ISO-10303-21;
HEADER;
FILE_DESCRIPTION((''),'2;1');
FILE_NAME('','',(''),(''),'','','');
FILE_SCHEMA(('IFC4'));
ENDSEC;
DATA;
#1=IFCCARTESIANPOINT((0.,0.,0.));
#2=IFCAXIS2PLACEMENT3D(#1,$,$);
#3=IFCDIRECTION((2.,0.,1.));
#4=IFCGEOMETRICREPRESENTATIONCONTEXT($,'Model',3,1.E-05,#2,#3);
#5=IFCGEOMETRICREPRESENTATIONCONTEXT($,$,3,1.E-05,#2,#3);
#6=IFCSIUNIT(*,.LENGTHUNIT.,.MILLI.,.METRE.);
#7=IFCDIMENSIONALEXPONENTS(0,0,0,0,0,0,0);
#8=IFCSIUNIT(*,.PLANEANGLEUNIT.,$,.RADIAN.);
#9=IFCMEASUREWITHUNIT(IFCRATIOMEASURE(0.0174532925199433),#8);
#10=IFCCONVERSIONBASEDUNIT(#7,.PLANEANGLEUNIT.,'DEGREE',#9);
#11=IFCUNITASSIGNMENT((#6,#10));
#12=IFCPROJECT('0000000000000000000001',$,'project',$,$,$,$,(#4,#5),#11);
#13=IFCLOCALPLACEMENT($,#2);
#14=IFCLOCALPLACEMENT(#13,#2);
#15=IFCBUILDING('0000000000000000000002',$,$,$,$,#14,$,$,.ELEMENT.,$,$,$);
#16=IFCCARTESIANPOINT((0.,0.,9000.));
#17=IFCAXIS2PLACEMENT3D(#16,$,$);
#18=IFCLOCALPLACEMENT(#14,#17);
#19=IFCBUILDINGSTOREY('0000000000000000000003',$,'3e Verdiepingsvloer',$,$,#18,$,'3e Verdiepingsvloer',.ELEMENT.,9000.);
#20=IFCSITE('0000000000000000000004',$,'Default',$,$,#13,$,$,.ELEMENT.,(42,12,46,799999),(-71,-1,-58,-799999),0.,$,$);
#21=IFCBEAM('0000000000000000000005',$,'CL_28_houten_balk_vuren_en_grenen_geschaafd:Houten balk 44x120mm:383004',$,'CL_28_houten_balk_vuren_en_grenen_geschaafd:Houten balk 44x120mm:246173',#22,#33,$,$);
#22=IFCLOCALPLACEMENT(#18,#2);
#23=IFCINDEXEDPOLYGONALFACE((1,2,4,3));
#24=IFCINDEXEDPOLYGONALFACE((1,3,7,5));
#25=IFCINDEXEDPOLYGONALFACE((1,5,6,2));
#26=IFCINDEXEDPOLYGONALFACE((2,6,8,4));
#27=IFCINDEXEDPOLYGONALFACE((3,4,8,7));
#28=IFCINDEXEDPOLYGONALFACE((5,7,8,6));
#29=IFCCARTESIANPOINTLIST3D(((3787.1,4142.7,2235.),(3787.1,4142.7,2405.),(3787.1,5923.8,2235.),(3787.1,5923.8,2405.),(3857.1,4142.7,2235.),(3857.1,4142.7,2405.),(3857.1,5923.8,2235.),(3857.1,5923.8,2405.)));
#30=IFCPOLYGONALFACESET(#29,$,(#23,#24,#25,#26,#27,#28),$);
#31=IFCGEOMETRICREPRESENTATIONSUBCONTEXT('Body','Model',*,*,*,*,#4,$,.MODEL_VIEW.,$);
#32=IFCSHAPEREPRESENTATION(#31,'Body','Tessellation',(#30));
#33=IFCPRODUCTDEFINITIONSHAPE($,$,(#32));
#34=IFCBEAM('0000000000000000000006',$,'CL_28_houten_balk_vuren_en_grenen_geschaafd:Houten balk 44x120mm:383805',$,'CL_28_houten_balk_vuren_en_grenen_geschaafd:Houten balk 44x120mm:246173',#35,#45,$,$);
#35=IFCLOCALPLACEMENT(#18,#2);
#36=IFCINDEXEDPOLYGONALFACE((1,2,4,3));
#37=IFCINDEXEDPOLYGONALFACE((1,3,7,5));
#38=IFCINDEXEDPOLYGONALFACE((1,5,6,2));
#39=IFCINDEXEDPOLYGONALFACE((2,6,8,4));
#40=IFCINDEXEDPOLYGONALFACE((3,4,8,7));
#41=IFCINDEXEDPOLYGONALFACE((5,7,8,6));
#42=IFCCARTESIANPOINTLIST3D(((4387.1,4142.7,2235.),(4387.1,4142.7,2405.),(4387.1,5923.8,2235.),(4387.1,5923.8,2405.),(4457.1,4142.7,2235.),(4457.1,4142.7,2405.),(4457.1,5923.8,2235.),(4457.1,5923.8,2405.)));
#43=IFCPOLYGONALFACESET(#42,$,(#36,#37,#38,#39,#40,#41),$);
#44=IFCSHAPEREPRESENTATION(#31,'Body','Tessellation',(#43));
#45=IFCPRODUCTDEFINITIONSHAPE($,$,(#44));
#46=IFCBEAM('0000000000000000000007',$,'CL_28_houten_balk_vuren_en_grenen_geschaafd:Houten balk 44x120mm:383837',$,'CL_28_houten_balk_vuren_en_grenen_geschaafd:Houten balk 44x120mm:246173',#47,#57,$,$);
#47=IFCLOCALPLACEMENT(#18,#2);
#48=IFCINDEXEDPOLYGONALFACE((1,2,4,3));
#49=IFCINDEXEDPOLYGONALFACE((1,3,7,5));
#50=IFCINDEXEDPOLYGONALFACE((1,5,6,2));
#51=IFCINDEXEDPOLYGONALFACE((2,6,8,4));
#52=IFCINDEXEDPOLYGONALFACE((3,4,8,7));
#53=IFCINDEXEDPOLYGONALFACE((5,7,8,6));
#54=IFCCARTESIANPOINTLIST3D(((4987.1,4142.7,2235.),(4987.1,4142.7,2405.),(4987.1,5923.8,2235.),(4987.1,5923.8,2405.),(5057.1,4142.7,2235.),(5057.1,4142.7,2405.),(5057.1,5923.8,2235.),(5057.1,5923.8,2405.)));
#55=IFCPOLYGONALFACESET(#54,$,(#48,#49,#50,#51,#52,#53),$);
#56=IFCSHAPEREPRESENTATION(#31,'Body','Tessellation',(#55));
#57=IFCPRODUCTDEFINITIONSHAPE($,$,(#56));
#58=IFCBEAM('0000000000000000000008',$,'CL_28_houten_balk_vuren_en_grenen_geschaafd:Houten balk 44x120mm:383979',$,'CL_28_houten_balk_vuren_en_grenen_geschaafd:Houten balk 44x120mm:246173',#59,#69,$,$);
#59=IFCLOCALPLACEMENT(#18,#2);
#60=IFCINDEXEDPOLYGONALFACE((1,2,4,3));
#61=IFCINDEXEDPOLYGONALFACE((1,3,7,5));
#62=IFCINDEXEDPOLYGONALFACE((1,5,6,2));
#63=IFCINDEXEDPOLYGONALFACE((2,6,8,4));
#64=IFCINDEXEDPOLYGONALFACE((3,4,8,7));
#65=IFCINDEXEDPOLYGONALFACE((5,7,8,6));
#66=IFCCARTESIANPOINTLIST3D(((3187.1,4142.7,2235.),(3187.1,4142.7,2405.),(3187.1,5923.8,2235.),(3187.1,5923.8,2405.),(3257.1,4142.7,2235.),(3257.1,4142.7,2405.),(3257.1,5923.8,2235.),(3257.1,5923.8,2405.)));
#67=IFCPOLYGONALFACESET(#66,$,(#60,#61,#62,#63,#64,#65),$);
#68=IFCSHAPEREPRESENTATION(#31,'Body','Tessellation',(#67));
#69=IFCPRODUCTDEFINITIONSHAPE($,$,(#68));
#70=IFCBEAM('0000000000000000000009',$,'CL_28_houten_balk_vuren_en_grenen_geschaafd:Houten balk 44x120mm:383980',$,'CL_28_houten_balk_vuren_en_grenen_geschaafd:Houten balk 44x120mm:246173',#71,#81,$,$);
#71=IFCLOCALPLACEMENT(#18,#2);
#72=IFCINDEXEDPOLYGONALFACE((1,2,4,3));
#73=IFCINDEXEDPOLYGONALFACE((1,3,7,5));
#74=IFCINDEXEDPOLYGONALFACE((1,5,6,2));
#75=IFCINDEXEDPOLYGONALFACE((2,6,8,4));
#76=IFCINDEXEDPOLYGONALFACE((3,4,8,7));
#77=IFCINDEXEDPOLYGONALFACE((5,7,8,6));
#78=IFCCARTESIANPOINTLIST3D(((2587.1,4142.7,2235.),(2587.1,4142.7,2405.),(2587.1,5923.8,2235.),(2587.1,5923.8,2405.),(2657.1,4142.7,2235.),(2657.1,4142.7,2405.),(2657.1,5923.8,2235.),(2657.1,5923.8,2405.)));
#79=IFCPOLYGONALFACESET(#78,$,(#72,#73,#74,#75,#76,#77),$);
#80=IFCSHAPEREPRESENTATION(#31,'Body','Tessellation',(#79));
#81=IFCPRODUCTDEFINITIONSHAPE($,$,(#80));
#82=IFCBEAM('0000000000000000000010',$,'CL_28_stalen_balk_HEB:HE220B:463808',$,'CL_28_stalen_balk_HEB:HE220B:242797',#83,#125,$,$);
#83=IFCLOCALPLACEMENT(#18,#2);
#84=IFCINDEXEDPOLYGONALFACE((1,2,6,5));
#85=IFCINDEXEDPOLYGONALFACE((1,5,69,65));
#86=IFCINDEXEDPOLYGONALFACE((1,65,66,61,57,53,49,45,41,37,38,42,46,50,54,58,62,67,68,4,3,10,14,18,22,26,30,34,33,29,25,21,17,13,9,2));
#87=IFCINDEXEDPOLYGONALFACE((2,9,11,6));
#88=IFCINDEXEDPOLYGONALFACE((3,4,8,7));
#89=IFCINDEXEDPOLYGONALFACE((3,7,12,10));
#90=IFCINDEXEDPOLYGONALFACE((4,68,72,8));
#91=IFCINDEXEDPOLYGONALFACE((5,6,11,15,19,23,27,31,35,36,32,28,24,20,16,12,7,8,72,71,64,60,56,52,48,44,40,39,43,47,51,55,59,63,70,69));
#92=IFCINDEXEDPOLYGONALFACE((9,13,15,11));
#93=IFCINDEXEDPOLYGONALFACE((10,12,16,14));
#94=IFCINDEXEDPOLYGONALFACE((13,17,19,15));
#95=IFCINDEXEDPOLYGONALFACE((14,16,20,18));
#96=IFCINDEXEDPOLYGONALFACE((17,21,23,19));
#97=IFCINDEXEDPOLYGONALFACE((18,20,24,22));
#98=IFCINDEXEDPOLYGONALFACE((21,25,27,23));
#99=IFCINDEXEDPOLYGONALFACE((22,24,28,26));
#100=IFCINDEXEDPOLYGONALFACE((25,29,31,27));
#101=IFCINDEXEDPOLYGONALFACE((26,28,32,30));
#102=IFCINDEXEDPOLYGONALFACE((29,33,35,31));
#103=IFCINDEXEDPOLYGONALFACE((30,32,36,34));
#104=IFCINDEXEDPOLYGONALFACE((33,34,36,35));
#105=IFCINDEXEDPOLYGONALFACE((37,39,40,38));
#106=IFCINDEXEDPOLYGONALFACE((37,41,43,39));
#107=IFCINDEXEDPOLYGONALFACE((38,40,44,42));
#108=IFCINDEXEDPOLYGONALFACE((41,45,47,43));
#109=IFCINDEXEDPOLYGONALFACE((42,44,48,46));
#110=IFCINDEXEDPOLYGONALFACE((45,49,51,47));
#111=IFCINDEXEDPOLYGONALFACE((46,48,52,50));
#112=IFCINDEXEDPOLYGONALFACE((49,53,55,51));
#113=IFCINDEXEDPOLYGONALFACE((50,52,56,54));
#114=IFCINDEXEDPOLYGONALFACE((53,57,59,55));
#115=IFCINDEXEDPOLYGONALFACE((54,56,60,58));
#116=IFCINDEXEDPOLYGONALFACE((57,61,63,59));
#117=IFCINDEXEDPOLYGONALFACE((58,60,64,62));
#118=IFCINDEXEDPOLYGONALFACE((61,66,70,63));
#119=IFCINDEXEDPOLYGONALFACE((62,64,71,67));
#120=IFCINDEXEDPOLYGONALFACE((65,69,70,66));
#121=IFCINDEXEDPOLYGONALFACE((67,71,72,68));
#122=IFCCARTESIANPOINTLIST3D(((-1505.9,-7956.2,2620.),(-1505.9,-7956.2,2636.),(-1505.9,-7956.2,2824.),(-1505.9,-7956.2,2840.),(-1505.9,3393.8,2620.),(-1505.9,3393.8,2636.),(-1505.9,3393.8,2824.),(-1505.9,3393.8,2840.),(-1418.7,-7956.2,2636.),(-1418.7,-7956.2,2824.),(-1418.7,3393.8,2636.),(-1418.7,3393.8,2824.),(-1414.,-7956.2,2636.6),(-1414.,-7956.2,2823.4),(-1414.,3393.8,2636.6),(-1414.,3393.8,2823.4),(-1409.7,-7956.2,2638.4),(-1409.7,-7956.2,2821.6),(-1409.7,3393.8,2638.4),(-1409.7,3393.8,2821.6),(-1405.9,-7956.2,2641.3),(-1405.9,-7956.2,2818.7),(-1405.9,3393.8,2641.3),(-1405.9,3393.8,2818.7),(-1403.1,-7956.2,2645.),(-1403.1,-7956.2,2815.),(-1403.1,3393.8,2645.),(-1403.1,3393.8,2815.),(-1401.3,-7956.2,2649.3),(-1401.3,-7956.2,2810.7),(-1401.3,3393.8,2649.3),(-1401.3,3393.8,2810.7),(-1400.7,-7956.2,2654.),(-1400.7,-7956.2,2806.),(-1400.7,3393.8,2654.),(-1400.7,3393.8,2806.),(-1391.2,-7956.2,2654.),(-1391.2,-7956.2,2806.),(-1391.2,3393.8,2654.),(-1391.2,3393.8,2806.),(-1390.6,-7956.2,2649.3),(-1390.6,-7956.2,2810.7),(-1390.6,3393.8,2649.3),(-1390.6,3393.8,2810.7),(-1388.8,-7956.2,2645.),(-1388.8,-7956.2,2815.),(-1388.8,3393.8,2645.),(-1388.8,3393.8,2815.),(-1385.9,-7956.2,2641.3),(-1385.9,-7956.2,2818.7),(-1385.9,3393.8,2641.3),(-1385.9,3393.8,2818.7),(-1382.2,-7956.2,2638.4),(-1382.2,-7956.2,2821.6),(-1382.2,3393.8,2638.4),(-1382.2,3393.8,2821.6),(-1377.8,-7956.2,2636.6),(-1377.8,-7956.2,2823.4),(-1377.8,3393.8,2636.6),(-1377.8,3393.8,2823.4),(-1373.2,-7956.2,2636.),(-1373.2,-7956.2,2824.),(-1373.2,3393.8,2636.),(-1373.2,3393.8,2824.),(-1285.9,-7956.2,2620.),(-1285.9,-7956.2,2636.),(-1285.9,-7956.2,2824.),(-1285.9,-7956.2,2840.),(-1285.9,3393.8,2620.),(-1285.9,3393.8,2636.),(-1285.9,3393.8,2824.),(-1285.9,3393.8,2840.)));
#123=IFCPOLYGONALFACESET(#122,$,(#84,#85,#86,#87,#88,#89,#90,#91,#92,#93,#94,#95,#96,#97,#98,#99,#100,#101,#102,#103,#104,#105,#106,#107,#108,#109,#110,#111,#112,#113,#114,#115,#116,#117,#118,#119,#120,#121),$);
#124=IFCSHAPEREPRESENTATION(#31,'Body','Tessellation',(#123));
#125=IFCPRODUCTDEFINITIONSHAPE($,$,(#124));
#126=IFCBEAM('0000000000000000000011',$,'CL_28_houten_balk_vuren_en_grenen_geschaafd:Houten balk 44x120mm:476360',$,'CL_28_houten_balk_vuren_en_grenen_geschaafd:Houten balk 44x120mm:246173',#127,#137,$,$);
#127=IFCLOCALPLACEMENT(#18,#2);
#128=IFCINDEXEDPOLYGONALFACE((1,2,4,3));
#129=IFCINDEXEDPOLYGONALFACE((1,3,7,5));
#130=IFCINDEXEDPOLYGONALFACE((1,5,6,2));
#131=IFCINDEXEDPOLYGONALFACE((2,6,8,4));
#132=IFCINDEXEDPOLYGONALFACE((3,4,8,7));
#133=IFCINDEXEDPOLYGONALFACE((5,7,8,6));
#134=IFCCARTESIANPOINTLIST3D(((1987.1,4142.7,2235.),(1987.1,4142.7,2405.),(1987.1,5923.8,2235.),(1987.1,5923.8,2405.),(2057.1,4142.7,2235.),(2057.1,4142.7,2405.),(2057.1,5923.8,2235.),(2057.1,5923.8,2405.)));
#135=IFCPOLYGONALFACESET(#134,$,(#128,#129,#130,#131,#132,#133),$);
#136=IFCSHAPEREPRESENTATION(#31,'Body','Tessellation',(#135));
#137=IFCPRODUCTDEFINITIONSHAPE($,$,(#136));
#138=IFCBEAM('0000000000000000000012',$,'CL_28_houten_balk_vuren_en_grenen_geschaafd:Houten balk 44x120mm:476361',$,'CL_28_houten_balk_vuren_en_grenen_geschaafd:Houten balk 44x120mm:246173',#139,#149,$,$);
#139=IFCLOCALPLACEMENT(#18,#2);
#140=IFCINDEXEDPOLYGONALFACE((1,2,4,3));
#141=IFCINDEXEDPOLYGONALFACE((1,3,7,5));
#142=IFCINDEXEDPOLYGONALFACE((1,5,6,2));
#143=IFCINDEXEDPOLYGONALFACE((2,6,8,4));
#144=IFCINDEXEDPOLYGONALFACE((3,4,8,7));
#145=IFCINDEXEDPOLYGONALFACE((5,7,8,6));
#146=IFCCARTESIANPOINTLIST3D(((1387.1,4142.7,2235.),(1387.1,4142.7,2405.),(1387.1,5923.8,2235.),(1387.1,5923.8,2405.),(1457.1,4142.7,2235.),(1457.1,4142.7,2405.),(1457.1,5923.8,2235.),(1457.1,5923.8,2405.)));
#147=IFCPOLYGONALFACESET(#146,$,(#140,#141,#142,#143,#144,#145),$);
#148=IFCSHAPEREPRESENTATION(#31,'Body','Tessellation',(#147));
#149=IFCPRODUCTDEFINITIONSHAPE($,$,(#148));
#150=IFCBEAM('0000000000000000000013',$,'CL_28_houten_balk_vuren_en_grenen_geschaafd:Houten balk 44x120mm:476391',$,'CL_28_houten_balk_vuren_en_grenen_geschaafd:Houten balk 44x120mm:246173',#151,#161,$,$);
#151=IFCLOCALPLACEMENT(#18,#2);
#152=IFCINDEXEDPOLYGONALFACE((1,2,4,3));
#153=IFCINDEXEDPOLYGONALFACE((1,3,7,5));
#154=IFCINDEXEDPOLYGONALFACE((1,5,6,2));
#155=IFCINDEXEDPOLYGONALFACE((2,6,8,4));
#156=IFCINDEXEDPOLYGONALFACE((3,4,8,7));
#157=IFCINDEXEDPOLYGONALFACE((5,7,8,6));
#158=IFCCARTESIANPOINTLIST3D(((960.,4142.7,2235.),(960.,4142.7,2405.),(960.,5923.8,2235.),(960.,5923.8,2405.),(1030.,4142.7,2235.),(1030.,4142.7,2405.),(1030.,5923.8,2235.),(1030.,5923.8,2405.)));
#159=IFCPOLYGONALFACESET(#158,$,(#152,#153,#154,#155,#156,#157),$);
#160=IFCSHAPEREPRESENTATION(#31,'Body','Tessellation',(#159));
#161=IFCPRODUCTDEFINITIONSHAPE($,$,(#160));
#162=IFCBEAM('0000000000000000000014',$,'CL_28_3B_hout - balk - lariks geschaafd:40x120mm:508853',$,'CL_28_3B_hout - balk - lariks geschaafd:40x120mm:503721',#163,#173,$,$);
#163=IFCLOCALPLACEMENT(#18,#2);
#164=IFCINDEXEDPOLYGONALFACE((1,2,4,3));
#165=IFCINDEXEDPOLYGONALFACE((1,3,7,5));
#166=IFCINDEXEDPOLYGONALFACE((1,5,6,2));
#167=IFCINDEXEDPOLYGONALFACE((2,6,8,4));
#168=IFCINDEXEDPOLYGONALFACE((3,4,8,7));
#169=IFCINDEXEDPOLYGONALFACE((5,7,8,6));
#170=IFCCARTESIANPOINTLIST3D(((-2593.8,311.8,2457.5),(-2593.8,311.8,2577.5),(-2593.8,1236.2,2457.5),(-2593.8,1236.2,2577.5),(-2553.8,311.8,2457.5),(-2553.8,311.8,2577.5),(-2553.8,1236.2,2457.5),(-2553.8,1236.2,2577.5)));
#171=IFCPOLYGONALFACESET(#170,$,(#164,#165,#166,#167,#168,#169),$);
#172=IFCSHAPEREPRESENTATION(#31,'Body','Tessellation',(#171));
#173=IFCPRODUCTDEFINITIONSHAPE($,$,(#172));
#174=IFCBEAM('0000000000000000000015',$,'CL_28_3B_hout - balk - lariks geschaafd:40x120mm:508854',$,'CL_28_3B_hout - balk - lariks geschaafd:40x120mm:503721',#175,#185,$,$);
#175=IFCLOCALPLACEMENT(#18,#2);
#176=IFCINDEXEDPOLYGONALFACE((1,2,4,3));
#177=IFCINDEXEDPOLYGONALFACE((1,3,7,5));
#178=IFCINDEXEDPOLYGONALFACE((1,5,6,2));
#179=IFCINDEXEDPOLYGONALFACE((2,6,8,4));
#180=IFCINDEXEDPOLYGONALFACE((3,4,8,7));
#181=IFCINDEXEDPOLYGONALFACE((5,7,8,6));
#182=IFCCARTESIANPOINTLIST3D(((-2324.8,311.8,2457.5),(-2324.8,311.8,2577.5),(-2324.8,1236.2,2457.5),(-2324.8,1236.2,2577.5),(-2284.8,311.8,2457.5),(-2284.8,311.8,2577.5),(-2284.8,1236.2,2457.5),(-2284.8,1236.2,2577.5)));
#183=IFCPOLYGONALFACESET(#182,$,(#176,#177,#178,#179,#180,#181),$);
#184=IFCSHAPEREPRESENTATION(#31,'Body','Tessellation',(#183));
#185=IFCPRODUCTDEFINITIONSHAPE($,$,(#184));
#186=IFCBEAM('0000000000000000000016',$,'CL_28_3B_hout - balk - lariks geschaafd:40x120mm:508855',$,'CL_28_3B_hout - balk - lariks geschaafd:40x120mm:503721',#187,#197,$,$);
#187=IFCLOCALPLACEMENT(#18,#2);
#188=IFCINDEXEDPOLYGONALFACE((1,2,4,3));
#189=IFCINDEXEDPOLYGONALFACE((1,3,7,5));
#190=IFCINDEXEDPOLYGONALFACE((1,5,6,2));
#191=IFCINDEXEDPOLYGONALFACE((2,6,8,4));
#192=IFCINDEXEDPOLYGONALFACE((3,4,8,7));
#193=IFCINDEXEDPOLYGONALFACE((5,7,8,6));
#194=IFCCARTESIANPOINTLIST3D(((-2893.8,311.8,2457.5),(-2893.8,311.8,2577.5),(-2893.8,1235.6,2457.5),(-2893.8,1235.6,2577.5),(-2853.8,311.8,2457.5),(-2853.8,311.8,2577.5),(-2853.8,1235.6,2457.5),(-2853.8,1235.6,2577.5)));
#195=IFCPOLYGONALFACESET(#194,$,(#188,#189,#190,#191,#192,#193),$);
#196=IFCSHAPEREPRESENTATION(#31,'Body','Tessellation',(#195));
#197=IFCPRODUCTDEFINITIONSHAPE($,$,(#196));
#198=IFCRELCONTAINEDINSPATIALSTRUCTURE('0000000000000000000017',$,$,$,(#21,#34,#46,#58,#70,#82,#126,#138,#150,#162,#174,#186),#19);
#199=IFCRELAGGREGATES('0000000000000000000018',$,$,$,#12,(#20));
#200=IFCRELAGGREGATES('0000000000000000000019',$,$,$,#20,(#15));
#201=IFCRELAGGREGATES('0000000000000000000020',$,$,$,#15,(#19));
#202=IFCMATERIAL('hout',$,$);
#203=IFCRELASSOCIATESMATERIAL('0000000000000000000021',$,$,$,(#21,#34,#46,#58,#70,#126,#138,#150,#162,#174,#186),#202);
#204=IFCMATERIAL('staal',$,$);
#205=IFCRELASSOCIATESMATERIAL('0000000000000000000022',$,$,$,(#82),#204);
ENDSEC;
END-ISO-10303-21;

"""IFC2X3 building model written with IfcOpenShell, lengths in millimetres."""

from ifc_helpers import new_model, entity, si_unit, converted_unit, direction, frame, frame_2d, origin, place, context, subcontext, project, spatial, rectangle, i_section, extrude, material, element, save


model = new_model("IFC2X3")

# Units and contexts
model_context = context("Model", 3, precision=1e-05, world=origin(), true_north=direction((2.0, 0.0, 1.0)))
context_of_model = context(None, 3, precision=1e-05, world=origin(), true_north=direction((2.0, 0.0, 1.0)))
body_context = subcontext(model_context, "Body", "Model", "MODEL_VIEW")
ifc_project = project(units=[si_unit("LENGTHUNIT", "METRE", prefix="MILLI"), converted_unit("PLANEANGLEUNIT", "DEGREE", entity("IfcRatioMeasure", 0.0174532925199433), si_unit("PLANEANGLEUNIT", "RADIAN"), dimensions=[0, 0, 0, 0, 0, 0, 0])], contexts=[model_context, context_of_model])

# Site, building, storey
site_placement = place(None, origin())
site = spatial("IfcSite", under=ifc_project, at=site_placement, Name="Default", CompositionType="ELEMENT", RefLatitude=(42, 12, 46, 799999), RefLongitude=(-71, -1, -58, -799999), RefElevation=0.0)
building_placement = place(site_placement, origin())
building = spatial("IfcBuilding", under=site, at=building_placement, CompositionType="ELEMENT")
storey_placement = place(building_placement, frame((0.0, 0.0, 9000.0)))
storey = spatial("IfcBuildingStorey", under=building, at=storey_placement, Name="3e Verdiepingsvloer", LongName="3e Verdiepingsvloer", CompositionType="ELEMENT", Elevation=9000.0)

# Beams
ifc_material_1 = material(Name="staal")
ifc_material_2 = material(Name="hout")
for number, where, z_axis, x_axis, name in (
    (1, (3822.1, 4142.7, 2405.0), (0.0, 0.0, 1.0), (0.0, 1.0, 0.0), "CL_28_houten_balk_vuren_en_grenen_geschaafd:Houten balk 44x120mm:383004"),
    (2, (4422.1, 4142.7, 2405.0), (0.0, 0.0, 1.0), (0.0, 1.0, 0.0), "CL_28_houten_balk_vuren_en_grenen_geschaafd:Houten balk 44x120mm:383805"),
):
    element("IfcBeam", number, at=place(storey_placement, frame(where, z_axis=z_axis, x_axis=x_axis)), inside=storey, material=ifc_material_2, Name=name, ObjectType="CL_28_houten_balk_vuren_en_grenen_geschaafd:Houten balk 44x120mm:246173", context=body_context, shape_type="SweptSolid", body=[
        extrude(rectangle(XDim=170.0, YDim=70.0, at=frame_2d((0.0, 0.0), x_axis=(1.0, 0.0))), frame((0.0, 0.0, -85.0), z_axis=(1.0, 0.0, 0.0), x_axis=(0.0, 0.0, -1.0)), (0.0, 0.0, 1.0), 1781.1),
    ])
beam_1_placement = place(storey_placement, frame((5022.1, 4142.7, 2405.0), z_axis=(0.0, 0.0, 1.0), x_axis=(0.0, 1.0, 0.0)))
element("IfcBeam", 3, at=beam_1_placement, inside=storey, material=ifc_material_2, Name="CL_28_houten_balk_vuren_en_grenen_geschaafd:Houten balk 44x120mm:383837", ObjectType="CL_28_houten_balk_vuren_en_grenen_geschaafd:Houten balk 44x120mm:246173", context=body_context, shape_type="SweptSolid", body=[
    extrude(rectangle(XDim=170.0, YDim=70.0, at=frame_2d((0.0, 0.0), x_axis=(1.0, 0.0))), frame((0.0, 0.0, -85.0), z_axis=(1.0, 0.0, 0.0), x_axis=(0.0, 0.0, -1.0)), (0.0, 0.0, 1.0), 1781.1),
])
for number, where, z_axis, x_axis, name in (
    (4, (3222.1, 4142.7, 2405.0), (0.0, 0.0, 1.0), (0.0, 1.0, 0.0), "CL_28_houten_balk_vuren_en_grenen_geschaafd:Houten balk 44x120mm:383979"),
    (5, (2622.1, 4142.7, 2405.0), (0.0, 0.0, 1.0), (0.0, 1.0, 0.0), "CL_28_houten_balk_vuren_en_grenen_geschaafd:Houten balk 44x120mm:383980"),
):
    element("IfcBeam", number, at=place(storey_placement, frame(where, z_axis=z_axis, x_axis=x_axis)), inside=storey, material=ifc_material_2, Name=name, ObjectType="CL_28_houten_balk_vuren_en_grenen_geschaafd:Houten balk 44x120mm:246173", context=body_context, shape_type="SweptSolid", body=[
        extrude(rectangle(XDim=170.0, YDim=70.0, at=frame_2d((0.0, 0.0), x_axis=(1.0, 0.0))), frame((0.0, 0.0, -85.0), z_axis=(1.0, 0.0, 0.0), x_axis=(0.0, 0.0, -1.0)), (0.0, 0.0, 1.0), 1781.1),
    ])
beam_2_placement = place(storey_placement, frame((-1395.9, -7956.2, 2840.0), z_axis=(0.0, 0.0, 1.0), x_axis=(0.0, 1.0, 0.0)))
element("IfcBeam", 6, at=beam_2_placement, inside=storey, material=ifc_material_1, Name="CL_28_stalen_balk_HEB:HE220B:463808", ObjectType="CL_28_stalen_balk_HEB:HE220B:242797", context=body_context, shape_type="SweptSolid", body=[
    extrude(i_section(OverallWidth=220.0, OverallDepth=220.0, WebThickness=9.5, FlangeThickness=16.0, FilletRadius=18.0, at=frame_2d((0.0, 0.0), x_axis=(0.0, 1.0))), frame((0.0, 0.0, -110.0), z_axis=(1.0, 0.0, 0.0), x_axis=(0.0, 0.0, -1.0)), (0.0, 0.0, 1.0), 11350.0),
])
for number, where, z_axis, x_axis, name in (
    (7, (2022.1, 4142.7, 2405.0), (0.0, 0.0, 1.0), (0.0, 1.0, 0.0), "CL_28_houten_balk_vuren_en_grenen_geschaafd:Houten balk 44x120mm:476360"),
    (8, (1422.1, 4142.7, 2405.0), (0.0, 0.0, 1.0), (0.0, 1.0, 0.0), "CL_28_houten_balk_vuren_en_grenen_geschaafd:Houten balk 44x120mm:476361"),
):
    element("IfcBeam", number, at=place(storey_placement, frame(where, z_axis=z_axis, x_axis=x_axis)), inside=storey, material=ifc_material_2, Name=name, ObjectType="CL_28_houten_balk_vuren_en_grenen_geschaafd:Houten balk 44x120mm:246173", context=body_context, shape_type="SweptSolid", body=[
        extrude(rectangle(XDim=170.0, YDim=70.0, at=frame_2d((0.0, 0.0), x_axis=(1.0, 0.0))), frame((0.0, 0.0, -85.0), z_axis=(1.0, 0.0, 0.0), x_axis=(0.0, 0.0, -1.0)), (0.0, 0.0, 1.0), 1781.1),
    ])
beam_3_placement = place(storey_placement, frame((995.0, 4142.7, 2405.0), z_axis=(0.0, 0.0, 1.0), x_axis=(0.0, 1.0, 0.0)))
element("IfcBeam", 9, at=beam_3_placement, inside=storey, material=ifc_material_2, Name="CL_28_houten_balk_vuren_en_grenen_geschaafd:Houten balk 44x120mm:476391", ObjectType="CL_28_houten_balk_vuren_en_grenen_geschaafd:Houten balk 44x120mm:246173", context=body_context, shape_type="SweptSolid", body=[
    extrude(rectangle(XDim=170.0, YDim=70.0, at=frame_2d((0.0, 0.0), x_axis=(1.0, 0.0))), frame((0.0, 0.0, -85.0), z_axis=(1.0, 0.0, 0.0), x_axis=(0.0, 0.0, -1.0)), (0.0, 0.0, 1.0), 1781.1),
])
beam_4_placement = place(storey_placement, frame((-2573.8, 1304.8, 2577.5), z_axis=(0.0, 0.0, 1.0), x_axis=(0.0, -1.0, 0.0)))
element("IfcBeam", 10, at=beam_4_placement, inside=storey, material=ifc_material_2, Name="CL_28_3B_hout - balk - lariks geschaafd:40x120mm:508853", ObjectType="CL_28_3B_hout - balk - lariks geschaafd:40x120mm:503721", context=body_context, shape_type="SweptSolid", body=[
    extrude(rectangle(XDim=120.0, YDim=40.0, at=frame_2d((0.0, 0.0), x_axis=(1.0, 0.0))), frame((68.6, 0.0, -60.0), z_axis=(1.0, 0.0, 0.0), x_axis=(0.0, 0.0, -1.0)), (0.0, 0.0, 1.0), 924.4),
])
beam_5_placement = place(storey_placement, frame((-2304.8, 1297.8, 2577.5), z_axis=(0.0, 0.0, 1.0), x_axis=(0.0, -1.0, 0.0)))
element("IfcBeam", 11, at=beam_5_placement, inside=storey, material=ifc_material_2, Name="CL_28_3B_hout - balk - lariks geschaafd:40x120mm:508854", ObjectType="CL_28_3B_hout - balk - lariks geschaafd:40x120mm:503721", context=body_context, shape_type="SweptSolid", body=[
    extrude(rectangle(XDim=120.0, YDim=40.0, at=frame_2d((0.0, 0.0), x_axis=(1.0, 0.0))), frame((61.6, 0.0, -60.0), z_axis=(1.0, 0.0, 0.0), x_axis=(0.0, 0.0, -1.0)), (0.0, 0.0, 1.0), 924.4),
])
beam_6_placement = place(storey_placement, frame((-2873.8, 1304.8, 2577.5), z_axis=(0.0, 0.0, 1.0), x_axis=(0.0, -1.0, 0.0)))
element("IfcBeam", 12, at=beam_6_placement, inside=storey, material=ifc_material_2, Name="CL_28_3B_hout - balk - lariks geschaafd:40x120mm:508855", ObjectType="CL_28_3B_hout - balk - lariks geschaafd:40x120mm:503721", context=body_context, shape_type="SweptSolid", body=[
    extrude(rectangle(XDim=120.0, YDim=40.0, at=frame_2d((0.0, 0.0), x_axis=(1.0, 0.0))), frame((69.1, 0.0, -60.0), z_axis=(1.0, 0.0, 0.0), x_axis=(0.0, 0.0, -1.0)), (0.0, 0.0, 1.0), 923.9),
])

save(model, "model.ifc")
